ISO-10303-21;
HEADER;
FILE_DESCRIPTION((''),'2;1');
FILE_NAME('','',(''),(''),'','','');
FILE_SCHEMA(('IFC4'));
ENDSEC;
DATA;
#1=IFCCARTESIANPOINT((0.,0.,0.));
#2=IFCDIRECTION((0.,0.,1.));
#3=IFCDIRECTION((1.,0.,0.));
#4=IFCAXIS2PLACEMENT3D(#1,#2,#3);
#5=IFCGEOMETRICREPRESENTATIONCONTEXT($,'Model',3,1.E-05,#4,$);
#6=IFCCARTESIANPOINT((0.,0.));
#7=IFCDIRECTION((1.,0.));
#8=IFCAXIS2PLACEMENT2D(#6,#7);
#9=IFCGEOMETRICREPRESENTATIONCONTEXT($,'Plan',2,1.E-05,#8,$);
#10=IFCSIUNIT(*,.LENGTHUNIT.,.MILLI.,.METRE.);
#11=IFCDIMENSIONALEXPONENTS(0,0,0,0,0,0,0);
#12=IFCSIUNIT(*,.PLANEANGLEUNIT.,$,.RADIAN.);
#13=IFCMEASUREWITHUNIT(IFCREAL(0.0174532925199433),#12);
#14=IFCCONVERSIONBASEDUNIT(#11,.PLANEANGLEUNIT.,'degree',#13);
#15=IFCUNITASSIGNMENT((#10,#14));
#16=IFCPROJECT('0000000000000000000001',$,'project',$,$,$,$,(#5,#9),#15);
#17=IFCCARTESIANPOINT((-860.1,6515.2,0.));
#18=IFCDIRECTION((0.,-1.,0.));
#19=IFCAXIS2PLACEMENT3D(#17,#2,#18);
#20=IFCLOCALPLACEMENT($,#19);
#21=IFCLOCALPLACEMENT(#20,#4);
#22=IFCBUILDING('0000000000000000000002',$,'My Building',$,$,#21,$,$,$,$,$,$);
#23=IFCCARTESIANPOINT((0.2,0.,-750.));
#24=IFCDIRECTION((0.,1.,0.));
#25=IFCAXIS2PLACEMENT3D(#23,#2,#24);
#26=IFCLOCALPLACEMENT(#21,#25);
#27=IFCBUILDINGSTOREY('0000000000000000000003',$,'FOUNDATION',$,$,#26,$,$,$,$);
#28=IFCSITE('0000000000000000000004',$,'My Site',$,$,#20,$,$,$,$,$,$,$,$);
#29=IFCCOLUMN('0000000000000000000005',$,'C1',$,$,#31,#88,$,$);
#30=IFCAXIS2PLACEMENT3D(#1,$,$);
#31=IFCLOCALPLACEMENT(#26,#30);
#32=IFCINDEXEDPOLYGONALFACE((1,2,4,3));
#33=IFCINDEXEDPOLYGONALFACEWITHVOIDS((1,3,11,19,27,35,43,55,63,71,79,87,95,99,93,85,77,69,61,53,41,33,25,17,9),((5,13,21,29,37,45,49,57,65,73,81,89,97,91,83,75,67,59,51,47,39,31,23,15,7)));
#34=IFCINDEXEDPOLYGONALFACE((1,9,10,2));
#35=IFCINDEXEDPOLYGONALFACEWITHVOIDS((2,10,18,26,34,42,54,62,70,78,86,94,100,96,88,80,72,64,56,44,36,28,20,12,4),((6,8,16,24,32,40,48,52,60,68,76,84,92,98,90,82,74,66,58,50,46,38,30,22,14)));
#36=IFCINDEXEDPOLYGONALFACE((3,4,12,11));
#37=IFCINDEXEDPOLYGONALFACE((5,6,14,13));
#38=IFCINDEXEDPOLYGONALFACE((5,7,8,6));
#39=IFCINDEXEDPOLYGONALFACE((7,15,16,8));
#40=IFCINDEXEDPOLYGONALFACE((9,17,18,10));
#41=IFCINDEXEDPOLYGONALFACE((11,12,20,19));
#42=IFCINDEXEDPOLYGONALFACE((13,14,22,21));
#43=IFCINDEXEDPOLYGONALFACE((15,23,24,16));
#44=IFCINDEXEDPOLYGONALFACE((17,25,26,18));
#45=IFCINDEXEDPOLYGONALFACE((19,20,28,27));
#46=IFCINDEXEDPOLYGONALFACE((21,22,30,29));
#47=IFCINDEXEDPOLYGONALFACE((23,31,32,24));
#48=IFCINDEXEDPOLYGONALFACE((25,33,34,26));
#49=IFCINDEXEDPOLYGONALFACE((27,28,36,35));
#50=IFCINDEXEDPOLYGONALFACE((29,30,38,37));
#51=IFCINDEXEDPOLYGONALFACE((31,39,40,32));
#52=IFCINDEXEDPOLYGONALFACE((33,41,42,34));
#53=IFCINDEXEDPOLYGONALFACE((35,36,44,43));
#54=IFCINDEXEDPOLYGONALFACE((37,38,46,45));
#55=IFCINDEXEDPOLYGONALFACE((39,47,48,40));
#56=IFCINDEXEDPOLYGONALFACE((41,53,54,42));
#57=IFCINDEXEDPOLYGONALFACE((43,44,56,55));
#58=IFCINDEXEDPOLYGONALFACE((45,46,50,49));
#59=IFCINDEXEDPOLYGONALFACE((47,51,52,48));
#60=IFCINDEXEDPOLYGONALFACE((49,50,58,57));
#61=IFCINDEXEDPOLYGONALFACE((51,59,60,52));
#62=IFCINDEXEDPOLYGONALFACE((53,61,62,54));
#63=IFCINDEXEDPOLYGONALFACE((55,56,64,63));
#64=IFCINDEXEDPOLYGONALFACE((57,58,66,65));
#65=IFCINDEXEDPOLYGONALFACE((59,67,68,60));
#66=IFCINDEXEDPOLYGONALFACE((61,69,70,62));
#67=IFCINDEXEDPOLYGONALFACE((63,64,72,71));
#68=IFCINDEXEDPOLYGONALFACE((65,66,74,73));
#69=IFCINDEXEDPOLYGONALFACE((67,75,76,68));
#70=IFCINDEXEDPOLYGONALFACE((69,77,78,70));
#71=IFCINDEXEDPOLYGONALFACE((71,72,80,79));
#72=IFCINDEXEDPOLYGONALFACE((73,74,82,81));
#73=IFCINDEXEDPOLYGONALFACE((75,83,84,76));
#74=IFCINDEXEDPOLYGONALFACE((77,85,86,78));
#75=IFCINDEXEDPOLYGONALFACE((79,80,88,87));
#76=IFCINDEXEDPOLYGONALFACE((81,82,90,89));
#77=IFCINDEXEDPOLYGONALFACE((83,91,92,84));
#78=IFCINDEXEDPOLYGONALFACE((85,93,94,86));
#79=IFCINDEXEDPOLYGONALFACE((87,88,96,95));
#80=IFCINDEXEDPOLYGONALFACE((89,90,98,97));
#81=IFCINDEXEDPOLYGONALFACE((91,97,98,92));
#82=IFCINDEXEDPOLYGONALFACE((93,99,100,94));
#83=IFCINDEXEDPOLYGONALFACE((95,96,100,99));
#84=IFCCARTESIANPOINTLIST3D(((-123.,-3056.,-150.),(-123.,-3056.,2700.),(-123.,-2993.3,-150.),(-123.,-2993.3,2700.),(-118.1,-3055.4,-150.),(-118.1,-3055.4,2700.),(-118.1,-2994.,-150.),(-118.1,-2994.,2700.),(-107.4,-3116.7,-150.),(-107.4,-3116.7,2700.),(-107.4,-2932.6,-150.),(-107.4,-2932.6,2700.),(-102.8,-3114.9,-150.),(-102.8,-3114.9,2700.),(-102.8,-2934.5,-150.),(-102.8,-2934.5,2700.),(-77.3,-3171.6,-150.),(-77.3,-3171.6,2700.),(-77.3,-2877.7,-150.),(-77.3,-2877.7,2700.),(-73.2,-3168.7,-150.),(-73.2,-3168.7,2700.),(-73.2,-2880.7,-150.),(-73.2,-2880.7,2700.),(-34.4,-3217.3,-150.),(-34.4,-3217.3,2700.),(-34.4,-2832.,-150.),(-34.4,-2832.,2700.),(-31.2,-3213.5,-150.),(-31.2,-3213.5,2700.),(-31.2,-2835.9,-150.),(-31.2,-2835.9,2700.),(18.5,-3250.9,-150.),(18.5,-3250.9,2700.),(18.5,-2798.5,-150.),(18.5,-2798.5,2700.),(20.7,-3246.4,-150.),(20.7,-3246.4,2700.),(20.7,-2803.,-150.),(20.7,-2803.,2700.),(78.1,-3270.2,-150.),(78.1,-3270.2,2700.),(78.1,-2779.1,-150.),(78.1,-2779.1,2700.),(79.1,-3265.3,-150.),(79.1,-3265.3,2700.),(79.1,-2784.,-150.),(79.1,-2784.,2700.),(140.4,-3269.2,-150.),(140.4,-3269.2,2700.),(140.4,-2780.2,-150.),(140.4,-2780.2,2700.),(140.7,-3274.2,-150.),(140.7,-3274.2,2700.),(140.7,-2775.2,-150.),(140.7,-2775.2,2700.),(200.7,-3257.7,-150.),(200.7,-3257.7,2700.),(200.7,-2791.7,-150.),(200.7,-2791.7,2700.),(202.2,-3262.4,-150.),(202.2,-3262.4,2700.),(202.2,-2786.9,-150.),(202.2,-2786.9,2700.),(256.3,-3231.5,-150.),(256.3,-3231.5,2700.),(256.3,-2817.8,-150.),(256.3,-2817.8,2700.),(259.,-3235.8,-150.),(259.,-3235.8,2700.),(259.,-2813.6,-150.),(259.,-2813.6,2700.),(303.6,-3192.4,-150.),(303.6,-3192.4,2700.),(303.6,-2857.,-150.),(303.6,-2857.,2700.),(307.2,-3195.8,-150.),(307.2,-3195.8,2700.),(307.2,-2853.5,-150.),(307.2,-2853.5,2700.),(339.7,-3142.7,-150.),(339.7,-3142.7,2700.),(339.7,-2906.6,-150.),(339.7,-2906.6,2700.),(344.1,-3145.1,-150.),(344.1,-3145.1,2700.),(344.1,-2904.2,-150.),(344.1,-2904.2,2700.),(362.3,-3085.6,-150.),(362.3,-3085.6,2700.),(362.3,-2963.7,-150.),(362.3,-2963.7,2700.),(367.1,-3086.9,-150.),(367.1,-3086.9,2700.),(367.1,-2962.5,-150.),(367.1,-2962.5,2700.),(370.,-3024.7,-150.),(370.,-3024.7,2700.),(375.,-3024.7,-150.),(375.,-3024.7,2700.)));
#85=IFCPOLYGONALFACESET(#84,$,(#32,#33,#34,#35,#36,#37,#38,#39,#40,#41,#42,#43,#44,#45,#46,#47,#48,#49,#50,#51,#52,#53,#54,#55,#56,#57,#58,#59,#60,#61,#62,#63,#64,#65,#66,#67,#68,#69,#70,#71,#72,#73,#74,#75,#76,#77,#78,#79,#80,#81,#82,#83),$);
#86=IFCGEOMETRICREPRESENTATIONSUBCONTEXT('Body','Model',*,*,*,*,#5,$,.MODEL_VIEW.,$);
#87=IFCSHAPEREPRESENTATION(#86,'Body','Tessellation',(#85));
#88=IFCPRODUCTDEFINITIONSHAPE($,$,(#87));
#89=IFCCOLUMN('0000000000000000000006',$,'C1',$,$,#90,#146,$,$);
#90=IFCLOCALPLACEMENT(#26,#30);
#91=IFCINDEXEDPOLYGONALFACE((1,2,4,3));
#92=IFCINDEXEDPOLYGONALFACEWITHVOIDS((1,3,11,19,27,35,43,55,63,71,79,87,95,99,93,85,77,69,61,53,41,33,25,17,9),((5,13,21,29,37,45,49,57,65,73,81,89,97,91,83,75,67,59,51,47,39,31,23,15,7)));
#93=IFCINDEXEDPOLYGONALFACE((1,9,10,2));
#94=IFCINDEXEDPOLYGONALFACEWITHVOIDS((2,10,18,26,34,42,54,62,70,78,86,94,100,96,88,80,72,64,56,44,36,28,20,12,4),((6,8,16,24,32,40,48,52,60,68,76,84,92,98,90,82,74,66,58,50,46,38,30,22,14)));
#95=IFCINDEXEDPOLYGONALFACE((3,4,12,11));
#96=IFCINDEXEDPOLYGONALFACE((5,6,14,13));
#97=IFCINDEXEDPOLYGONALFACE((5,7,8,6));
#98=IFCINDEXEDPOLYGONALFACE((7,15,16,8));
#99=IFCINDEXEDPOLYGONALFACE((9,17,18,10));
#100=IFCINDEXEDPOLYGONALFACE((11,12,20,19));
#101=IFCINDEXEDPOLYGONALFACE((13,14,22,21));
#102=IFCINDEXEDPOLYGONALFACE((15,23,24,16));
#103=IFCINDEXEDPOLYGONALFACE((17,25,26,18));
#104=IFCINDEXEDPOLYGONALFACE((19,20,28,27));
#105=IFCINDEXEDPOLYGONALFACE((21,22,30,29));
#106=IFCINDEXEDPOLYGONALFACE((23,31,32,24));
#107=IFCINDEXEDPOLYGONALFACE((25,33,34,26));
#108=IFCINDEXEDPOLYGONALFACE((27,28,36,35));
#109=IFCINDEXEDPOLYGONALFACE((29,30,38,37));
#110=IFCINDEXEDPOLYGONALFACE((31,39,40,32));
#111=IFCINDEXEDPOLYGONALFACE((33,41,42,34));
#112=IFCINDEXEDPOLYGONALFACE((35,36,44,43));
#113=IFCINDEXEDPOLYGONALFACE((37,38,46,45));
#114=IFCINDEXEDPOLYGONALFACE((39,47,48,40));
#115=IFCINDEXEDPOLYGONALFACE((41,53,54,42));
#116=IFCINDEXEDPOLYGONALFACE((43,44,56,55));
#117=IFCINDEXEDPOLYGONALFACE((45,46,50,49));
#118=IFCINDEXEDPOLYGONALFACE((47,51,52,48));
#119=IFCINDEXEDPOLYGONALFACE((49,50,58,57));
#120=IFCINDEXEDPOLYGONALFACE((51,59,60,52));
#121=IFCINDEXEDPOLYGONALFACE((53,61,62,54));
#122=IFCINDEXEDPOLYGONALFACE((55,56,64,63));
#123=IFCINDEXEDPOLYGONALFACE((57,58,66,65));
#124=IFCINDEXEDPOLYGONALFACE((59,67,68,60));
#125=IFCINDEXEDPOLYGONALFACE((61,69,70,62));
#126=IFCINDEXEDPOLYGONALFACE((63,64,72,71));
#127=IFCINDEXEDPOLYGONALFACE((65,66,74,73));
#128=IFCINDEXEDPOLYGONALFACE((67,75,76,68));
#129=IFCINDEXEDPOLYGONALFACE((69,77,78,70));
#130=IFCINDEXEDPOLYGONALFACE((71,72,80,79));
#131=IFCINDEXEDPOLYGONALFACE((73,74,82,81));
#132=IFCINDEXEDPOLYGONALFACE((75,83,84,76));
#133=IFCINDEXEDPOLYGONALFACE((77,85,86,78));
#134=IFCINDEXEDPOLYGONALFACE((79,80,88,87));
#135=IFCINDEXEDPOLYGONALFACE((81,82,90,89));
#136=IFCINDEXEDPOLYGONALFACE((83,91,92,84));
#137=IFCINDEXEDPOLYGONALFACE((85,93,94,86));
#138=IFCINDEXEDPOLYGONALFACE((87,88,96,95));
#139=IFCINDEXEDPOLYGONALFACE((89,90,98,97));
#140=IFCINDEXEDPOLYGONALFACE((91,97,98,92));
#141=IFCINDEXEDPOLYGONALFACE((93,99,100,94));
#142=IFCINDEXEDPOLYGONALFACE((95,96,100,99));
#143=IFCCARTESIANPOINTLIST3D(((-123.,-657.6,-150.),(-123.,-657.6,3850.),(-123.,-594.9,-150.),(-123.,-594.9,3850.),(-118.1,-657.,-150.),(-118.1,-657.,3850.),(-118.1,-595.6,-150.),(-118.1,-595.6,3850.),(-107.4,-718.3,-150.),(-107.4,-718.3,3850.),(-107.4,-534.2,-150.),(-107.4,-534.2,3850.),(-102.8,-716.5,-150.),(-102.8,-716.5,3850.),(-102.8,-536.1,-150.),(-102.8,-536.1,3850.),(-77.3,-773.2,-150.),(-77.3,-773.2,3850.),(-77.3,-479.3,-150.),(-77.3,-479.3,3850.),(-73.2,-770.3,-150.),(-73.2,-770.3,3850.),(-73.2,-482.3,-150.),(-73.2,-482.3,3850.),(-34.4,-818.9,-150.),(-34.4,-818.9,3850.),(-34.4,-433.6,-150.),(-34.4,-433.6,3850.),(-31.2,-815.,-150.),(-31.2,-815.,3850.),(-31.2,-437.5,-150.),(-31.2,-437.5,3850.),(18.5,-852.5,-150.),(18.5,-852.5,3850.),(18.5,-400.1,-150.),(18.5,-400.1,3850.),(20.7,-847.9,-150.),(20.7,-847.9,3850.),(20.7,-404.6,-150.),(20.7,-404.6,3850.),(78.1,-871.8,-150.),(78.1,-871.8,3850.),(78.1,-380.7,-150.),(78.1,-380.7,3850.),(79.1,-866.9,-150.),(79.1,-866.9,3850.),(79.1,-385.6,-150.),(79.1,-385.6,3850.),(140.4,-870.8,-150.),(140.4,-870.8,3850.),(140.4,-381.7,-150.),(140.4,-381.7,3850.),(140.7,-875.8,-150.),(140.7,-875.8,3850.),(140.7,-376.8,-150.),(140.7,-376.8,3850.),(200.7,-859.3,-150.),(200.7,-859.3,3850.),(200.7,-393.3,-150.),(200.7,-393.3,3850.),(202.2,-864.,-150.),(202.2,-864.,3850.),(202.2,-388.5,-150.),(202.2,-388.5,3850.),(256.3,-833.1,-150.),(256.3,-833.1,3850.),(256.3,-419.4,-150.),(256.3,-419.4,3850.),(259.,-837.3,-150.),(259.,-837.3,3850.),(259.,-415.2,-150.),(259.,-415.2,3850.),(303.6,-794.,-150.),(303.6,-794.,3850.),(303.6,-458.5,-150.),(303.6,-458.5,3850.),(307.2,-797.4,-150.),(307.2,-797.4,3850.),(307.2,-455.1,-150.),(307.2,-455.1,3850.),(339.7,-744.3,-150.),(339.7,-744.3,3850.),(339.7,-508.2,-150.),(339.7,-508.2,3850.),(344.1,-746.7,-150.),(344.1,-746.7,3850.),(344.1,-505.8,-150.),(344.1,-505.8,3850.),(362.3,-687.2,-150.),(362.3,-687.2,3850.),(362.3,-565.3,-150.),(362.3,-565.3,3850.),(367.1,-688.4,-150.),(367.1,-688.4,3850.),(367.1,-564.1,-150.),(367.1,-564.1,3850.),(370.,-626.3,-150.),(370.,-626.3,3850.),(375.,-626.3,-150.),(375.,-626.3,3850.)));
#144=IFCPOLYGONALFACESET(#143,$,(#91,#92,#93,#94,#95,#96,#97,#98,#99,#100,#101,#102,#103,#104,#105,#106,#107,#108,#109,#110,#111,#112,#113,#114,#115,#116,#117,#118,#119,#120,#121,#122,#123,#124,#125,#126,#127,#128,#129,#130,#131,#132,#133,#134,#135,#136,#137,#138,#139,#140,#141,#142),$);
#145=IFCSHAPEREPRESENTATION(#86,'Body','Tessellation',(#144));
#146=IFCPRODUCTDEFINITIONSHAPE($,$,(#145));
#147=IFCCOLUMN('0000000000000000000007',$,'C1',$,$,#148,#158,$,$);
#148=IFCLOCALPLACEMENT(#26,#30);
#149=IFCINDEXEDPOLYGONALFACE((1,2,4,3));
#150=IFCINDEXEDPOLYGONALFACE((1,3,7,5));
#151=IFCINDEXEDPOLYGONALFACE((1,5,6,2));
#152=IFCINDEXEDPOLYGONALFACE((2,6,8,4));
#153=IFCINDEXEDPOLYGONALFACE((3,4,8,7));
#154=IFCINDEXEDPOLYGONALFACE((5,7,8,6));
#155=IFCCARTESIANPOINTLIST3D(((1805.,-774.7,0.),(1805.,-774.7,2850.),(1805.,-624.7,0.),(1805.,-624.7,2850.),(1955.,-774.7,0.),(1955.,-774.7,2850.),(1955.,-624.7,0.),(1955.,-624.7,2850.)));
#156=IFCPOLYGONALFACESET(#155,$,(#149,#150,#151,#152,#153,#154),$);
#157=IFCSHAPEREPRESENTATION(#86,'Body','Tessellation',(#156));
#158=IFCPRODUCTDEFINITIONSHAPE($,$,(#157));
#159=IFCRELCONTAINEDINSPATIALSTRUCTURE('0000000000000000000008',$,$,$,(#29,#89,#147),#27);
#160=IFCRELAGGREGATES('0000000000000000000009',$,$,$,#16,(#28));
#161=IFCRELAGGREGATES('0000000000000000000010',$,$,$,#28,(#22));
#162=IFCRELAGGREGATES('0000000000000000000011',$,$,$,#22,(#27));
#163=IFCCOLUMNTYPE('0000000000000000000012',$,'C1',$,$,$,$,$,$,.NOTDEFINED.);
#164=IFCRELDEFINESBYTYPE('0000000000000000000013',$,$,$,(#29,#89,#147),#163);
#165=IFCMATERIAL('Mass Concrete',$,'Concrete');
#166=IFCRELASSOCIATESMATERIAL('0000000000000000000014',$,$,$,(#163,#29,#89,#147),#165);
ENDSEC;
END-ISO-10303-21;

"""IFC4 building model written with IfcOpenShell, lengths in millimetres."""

from ifc_helpers import new_model, entity, si_unit, converted_unit, frame, origin_with_axes, origin_2d_with_axis, place, context, subcontext, project, spatial, rectangle, hollow_circle, extrude, material, material_profile, profile_set, profile_usage, type_object, element, save


model = new_model("IFC4")

# Units and contexts
model_context = context("Model", 3, precision=1e-05, world=origin_with_axes())
plan_context = context("Plan", 2, precision=1e-05, world=origin_2d_with_axis())
body_context = subcontext(model_context, "Body", "Model", "MODEL_VIEW")
ifc_project = project(units=[si_unit("LENGTHUNIT", "METRE", prefix="MILLI"), converted_unit("PLANEANGLEUNIT", "degree", entity("IfcReal", 0.0174532925199433), si_unit("PLANEANGLEUNIT", "RADIAN"), dimensions=[0, 0, 0, 0, 0, 0, 0])], contexts=[model_context, plan_context])

# Site, building, storey
site_placement = place(None, frame((-860.1, 6515.2, 0.0), z_axis=(0.0, 0.0, 1.0), x_axis=(0.0, -1.0, 0.0)))
site = spatial("IfcSite", under=ifc_project, at=site_placement, Name="My Site")
building_placement = place(site_placement, frame((0.0, 0.0, 0.0), z_axis=(0.0, 0.0, 1.0), x_axis=(1.0, 0.0, 0.0)))
building = spatial("IfcBuilding", under=site, at=building_placement, Name="My Building")
storey_placement = place(building_placement, frame((0.2, 0.0, -750.0), z_axis=(0.0, 0.0, 1.0), x_axis=(0.0, 1.0, 0.0)))
storey = spatial("IfcBuildingStorey", under=building, at=storey_placement, Name="FOUNDATION")

# Shared definitions
ifc_material_1 = material(Name="Mass Concrete", Category="Concrete")

# Columns
ifc_material_profile = material_profile(ifc_material_1, rectangle(XDim=150.0, YDim=150.0), Name="Square Column", Category="Structure", Priority=1)
ifc_profile_set = profile_set([ifc_material_profile], Name="RC_COL_150x150")
column_type = type_object("IfcColumnType", Name="C1", PredefinedType="NOTDEFINED", material=ifc_profile_set)
ifc_profile_usage_1 = profile_usage(ifc_profile_set, cardinal=5)
column_1_placement = place(storey_placement, frame((125.0, -3024.7, -150.0), z_axis=(0.0, 0.0, 1.0), x_axis=(1.0, 0.0, 0.0)))
element("IfcColumn", 1, at=column_1_placement, inside=storey, type_object=column_type, material=ifc_profile_usage_1, Name="C1", context=body_context, shape_type="SweptSolid", body=[
    extrude(hollow_circle(Radius=250.0, WallThickness=5.0), origin_with_axes(), (0.0, 0.0, 1.0), 2850.0),
])
ifc_profile_usage_2 = profile_usage(ifc_profile_set, cardinal=5)
column_2_placement = place(storey_placement, frame((125.0, -626.3, -150.0), z_axis=(0.0, 0.0, 1.0), x_axis=(1.0, 0.0, 0.0)))
element("IfcColumn", 2, at=column_2_placement, inside=storey, type_object=column_type, material=ifc_profile_usage_2, Name="C1", context=body_context, shape_type="SweptSolid", body=[
    extrude(hollow_circle(Radius=250.0, WallThickness=5.0), origin_with_axes(), (0.0, 0.0, 1.0), 4000.0),
])
ifc_profile_usage_3 = profile_usage(ifc_profile_set, cardinal=5)
column_3_placement = place(storey_placement, frame((1880.0, -699.7, 0.0), z_axis=(0.0, 0.0, 1.0), x_axis=(1.0, 0.0, 0.0)))
element("IfcColumn", 3, at=column_3_placement, inside=storey, type_object=column_type, material=ifc_profile_usage_3, Name="C1", context=body_context, shape_type="SweptSolid", body=[
    extrude(rectangle(XDim=150.0, YDim=150.0), origin_with_axes(), (0.0, 0.0, 1.0), 2850.0),
])

save(model, "model.ifc")
